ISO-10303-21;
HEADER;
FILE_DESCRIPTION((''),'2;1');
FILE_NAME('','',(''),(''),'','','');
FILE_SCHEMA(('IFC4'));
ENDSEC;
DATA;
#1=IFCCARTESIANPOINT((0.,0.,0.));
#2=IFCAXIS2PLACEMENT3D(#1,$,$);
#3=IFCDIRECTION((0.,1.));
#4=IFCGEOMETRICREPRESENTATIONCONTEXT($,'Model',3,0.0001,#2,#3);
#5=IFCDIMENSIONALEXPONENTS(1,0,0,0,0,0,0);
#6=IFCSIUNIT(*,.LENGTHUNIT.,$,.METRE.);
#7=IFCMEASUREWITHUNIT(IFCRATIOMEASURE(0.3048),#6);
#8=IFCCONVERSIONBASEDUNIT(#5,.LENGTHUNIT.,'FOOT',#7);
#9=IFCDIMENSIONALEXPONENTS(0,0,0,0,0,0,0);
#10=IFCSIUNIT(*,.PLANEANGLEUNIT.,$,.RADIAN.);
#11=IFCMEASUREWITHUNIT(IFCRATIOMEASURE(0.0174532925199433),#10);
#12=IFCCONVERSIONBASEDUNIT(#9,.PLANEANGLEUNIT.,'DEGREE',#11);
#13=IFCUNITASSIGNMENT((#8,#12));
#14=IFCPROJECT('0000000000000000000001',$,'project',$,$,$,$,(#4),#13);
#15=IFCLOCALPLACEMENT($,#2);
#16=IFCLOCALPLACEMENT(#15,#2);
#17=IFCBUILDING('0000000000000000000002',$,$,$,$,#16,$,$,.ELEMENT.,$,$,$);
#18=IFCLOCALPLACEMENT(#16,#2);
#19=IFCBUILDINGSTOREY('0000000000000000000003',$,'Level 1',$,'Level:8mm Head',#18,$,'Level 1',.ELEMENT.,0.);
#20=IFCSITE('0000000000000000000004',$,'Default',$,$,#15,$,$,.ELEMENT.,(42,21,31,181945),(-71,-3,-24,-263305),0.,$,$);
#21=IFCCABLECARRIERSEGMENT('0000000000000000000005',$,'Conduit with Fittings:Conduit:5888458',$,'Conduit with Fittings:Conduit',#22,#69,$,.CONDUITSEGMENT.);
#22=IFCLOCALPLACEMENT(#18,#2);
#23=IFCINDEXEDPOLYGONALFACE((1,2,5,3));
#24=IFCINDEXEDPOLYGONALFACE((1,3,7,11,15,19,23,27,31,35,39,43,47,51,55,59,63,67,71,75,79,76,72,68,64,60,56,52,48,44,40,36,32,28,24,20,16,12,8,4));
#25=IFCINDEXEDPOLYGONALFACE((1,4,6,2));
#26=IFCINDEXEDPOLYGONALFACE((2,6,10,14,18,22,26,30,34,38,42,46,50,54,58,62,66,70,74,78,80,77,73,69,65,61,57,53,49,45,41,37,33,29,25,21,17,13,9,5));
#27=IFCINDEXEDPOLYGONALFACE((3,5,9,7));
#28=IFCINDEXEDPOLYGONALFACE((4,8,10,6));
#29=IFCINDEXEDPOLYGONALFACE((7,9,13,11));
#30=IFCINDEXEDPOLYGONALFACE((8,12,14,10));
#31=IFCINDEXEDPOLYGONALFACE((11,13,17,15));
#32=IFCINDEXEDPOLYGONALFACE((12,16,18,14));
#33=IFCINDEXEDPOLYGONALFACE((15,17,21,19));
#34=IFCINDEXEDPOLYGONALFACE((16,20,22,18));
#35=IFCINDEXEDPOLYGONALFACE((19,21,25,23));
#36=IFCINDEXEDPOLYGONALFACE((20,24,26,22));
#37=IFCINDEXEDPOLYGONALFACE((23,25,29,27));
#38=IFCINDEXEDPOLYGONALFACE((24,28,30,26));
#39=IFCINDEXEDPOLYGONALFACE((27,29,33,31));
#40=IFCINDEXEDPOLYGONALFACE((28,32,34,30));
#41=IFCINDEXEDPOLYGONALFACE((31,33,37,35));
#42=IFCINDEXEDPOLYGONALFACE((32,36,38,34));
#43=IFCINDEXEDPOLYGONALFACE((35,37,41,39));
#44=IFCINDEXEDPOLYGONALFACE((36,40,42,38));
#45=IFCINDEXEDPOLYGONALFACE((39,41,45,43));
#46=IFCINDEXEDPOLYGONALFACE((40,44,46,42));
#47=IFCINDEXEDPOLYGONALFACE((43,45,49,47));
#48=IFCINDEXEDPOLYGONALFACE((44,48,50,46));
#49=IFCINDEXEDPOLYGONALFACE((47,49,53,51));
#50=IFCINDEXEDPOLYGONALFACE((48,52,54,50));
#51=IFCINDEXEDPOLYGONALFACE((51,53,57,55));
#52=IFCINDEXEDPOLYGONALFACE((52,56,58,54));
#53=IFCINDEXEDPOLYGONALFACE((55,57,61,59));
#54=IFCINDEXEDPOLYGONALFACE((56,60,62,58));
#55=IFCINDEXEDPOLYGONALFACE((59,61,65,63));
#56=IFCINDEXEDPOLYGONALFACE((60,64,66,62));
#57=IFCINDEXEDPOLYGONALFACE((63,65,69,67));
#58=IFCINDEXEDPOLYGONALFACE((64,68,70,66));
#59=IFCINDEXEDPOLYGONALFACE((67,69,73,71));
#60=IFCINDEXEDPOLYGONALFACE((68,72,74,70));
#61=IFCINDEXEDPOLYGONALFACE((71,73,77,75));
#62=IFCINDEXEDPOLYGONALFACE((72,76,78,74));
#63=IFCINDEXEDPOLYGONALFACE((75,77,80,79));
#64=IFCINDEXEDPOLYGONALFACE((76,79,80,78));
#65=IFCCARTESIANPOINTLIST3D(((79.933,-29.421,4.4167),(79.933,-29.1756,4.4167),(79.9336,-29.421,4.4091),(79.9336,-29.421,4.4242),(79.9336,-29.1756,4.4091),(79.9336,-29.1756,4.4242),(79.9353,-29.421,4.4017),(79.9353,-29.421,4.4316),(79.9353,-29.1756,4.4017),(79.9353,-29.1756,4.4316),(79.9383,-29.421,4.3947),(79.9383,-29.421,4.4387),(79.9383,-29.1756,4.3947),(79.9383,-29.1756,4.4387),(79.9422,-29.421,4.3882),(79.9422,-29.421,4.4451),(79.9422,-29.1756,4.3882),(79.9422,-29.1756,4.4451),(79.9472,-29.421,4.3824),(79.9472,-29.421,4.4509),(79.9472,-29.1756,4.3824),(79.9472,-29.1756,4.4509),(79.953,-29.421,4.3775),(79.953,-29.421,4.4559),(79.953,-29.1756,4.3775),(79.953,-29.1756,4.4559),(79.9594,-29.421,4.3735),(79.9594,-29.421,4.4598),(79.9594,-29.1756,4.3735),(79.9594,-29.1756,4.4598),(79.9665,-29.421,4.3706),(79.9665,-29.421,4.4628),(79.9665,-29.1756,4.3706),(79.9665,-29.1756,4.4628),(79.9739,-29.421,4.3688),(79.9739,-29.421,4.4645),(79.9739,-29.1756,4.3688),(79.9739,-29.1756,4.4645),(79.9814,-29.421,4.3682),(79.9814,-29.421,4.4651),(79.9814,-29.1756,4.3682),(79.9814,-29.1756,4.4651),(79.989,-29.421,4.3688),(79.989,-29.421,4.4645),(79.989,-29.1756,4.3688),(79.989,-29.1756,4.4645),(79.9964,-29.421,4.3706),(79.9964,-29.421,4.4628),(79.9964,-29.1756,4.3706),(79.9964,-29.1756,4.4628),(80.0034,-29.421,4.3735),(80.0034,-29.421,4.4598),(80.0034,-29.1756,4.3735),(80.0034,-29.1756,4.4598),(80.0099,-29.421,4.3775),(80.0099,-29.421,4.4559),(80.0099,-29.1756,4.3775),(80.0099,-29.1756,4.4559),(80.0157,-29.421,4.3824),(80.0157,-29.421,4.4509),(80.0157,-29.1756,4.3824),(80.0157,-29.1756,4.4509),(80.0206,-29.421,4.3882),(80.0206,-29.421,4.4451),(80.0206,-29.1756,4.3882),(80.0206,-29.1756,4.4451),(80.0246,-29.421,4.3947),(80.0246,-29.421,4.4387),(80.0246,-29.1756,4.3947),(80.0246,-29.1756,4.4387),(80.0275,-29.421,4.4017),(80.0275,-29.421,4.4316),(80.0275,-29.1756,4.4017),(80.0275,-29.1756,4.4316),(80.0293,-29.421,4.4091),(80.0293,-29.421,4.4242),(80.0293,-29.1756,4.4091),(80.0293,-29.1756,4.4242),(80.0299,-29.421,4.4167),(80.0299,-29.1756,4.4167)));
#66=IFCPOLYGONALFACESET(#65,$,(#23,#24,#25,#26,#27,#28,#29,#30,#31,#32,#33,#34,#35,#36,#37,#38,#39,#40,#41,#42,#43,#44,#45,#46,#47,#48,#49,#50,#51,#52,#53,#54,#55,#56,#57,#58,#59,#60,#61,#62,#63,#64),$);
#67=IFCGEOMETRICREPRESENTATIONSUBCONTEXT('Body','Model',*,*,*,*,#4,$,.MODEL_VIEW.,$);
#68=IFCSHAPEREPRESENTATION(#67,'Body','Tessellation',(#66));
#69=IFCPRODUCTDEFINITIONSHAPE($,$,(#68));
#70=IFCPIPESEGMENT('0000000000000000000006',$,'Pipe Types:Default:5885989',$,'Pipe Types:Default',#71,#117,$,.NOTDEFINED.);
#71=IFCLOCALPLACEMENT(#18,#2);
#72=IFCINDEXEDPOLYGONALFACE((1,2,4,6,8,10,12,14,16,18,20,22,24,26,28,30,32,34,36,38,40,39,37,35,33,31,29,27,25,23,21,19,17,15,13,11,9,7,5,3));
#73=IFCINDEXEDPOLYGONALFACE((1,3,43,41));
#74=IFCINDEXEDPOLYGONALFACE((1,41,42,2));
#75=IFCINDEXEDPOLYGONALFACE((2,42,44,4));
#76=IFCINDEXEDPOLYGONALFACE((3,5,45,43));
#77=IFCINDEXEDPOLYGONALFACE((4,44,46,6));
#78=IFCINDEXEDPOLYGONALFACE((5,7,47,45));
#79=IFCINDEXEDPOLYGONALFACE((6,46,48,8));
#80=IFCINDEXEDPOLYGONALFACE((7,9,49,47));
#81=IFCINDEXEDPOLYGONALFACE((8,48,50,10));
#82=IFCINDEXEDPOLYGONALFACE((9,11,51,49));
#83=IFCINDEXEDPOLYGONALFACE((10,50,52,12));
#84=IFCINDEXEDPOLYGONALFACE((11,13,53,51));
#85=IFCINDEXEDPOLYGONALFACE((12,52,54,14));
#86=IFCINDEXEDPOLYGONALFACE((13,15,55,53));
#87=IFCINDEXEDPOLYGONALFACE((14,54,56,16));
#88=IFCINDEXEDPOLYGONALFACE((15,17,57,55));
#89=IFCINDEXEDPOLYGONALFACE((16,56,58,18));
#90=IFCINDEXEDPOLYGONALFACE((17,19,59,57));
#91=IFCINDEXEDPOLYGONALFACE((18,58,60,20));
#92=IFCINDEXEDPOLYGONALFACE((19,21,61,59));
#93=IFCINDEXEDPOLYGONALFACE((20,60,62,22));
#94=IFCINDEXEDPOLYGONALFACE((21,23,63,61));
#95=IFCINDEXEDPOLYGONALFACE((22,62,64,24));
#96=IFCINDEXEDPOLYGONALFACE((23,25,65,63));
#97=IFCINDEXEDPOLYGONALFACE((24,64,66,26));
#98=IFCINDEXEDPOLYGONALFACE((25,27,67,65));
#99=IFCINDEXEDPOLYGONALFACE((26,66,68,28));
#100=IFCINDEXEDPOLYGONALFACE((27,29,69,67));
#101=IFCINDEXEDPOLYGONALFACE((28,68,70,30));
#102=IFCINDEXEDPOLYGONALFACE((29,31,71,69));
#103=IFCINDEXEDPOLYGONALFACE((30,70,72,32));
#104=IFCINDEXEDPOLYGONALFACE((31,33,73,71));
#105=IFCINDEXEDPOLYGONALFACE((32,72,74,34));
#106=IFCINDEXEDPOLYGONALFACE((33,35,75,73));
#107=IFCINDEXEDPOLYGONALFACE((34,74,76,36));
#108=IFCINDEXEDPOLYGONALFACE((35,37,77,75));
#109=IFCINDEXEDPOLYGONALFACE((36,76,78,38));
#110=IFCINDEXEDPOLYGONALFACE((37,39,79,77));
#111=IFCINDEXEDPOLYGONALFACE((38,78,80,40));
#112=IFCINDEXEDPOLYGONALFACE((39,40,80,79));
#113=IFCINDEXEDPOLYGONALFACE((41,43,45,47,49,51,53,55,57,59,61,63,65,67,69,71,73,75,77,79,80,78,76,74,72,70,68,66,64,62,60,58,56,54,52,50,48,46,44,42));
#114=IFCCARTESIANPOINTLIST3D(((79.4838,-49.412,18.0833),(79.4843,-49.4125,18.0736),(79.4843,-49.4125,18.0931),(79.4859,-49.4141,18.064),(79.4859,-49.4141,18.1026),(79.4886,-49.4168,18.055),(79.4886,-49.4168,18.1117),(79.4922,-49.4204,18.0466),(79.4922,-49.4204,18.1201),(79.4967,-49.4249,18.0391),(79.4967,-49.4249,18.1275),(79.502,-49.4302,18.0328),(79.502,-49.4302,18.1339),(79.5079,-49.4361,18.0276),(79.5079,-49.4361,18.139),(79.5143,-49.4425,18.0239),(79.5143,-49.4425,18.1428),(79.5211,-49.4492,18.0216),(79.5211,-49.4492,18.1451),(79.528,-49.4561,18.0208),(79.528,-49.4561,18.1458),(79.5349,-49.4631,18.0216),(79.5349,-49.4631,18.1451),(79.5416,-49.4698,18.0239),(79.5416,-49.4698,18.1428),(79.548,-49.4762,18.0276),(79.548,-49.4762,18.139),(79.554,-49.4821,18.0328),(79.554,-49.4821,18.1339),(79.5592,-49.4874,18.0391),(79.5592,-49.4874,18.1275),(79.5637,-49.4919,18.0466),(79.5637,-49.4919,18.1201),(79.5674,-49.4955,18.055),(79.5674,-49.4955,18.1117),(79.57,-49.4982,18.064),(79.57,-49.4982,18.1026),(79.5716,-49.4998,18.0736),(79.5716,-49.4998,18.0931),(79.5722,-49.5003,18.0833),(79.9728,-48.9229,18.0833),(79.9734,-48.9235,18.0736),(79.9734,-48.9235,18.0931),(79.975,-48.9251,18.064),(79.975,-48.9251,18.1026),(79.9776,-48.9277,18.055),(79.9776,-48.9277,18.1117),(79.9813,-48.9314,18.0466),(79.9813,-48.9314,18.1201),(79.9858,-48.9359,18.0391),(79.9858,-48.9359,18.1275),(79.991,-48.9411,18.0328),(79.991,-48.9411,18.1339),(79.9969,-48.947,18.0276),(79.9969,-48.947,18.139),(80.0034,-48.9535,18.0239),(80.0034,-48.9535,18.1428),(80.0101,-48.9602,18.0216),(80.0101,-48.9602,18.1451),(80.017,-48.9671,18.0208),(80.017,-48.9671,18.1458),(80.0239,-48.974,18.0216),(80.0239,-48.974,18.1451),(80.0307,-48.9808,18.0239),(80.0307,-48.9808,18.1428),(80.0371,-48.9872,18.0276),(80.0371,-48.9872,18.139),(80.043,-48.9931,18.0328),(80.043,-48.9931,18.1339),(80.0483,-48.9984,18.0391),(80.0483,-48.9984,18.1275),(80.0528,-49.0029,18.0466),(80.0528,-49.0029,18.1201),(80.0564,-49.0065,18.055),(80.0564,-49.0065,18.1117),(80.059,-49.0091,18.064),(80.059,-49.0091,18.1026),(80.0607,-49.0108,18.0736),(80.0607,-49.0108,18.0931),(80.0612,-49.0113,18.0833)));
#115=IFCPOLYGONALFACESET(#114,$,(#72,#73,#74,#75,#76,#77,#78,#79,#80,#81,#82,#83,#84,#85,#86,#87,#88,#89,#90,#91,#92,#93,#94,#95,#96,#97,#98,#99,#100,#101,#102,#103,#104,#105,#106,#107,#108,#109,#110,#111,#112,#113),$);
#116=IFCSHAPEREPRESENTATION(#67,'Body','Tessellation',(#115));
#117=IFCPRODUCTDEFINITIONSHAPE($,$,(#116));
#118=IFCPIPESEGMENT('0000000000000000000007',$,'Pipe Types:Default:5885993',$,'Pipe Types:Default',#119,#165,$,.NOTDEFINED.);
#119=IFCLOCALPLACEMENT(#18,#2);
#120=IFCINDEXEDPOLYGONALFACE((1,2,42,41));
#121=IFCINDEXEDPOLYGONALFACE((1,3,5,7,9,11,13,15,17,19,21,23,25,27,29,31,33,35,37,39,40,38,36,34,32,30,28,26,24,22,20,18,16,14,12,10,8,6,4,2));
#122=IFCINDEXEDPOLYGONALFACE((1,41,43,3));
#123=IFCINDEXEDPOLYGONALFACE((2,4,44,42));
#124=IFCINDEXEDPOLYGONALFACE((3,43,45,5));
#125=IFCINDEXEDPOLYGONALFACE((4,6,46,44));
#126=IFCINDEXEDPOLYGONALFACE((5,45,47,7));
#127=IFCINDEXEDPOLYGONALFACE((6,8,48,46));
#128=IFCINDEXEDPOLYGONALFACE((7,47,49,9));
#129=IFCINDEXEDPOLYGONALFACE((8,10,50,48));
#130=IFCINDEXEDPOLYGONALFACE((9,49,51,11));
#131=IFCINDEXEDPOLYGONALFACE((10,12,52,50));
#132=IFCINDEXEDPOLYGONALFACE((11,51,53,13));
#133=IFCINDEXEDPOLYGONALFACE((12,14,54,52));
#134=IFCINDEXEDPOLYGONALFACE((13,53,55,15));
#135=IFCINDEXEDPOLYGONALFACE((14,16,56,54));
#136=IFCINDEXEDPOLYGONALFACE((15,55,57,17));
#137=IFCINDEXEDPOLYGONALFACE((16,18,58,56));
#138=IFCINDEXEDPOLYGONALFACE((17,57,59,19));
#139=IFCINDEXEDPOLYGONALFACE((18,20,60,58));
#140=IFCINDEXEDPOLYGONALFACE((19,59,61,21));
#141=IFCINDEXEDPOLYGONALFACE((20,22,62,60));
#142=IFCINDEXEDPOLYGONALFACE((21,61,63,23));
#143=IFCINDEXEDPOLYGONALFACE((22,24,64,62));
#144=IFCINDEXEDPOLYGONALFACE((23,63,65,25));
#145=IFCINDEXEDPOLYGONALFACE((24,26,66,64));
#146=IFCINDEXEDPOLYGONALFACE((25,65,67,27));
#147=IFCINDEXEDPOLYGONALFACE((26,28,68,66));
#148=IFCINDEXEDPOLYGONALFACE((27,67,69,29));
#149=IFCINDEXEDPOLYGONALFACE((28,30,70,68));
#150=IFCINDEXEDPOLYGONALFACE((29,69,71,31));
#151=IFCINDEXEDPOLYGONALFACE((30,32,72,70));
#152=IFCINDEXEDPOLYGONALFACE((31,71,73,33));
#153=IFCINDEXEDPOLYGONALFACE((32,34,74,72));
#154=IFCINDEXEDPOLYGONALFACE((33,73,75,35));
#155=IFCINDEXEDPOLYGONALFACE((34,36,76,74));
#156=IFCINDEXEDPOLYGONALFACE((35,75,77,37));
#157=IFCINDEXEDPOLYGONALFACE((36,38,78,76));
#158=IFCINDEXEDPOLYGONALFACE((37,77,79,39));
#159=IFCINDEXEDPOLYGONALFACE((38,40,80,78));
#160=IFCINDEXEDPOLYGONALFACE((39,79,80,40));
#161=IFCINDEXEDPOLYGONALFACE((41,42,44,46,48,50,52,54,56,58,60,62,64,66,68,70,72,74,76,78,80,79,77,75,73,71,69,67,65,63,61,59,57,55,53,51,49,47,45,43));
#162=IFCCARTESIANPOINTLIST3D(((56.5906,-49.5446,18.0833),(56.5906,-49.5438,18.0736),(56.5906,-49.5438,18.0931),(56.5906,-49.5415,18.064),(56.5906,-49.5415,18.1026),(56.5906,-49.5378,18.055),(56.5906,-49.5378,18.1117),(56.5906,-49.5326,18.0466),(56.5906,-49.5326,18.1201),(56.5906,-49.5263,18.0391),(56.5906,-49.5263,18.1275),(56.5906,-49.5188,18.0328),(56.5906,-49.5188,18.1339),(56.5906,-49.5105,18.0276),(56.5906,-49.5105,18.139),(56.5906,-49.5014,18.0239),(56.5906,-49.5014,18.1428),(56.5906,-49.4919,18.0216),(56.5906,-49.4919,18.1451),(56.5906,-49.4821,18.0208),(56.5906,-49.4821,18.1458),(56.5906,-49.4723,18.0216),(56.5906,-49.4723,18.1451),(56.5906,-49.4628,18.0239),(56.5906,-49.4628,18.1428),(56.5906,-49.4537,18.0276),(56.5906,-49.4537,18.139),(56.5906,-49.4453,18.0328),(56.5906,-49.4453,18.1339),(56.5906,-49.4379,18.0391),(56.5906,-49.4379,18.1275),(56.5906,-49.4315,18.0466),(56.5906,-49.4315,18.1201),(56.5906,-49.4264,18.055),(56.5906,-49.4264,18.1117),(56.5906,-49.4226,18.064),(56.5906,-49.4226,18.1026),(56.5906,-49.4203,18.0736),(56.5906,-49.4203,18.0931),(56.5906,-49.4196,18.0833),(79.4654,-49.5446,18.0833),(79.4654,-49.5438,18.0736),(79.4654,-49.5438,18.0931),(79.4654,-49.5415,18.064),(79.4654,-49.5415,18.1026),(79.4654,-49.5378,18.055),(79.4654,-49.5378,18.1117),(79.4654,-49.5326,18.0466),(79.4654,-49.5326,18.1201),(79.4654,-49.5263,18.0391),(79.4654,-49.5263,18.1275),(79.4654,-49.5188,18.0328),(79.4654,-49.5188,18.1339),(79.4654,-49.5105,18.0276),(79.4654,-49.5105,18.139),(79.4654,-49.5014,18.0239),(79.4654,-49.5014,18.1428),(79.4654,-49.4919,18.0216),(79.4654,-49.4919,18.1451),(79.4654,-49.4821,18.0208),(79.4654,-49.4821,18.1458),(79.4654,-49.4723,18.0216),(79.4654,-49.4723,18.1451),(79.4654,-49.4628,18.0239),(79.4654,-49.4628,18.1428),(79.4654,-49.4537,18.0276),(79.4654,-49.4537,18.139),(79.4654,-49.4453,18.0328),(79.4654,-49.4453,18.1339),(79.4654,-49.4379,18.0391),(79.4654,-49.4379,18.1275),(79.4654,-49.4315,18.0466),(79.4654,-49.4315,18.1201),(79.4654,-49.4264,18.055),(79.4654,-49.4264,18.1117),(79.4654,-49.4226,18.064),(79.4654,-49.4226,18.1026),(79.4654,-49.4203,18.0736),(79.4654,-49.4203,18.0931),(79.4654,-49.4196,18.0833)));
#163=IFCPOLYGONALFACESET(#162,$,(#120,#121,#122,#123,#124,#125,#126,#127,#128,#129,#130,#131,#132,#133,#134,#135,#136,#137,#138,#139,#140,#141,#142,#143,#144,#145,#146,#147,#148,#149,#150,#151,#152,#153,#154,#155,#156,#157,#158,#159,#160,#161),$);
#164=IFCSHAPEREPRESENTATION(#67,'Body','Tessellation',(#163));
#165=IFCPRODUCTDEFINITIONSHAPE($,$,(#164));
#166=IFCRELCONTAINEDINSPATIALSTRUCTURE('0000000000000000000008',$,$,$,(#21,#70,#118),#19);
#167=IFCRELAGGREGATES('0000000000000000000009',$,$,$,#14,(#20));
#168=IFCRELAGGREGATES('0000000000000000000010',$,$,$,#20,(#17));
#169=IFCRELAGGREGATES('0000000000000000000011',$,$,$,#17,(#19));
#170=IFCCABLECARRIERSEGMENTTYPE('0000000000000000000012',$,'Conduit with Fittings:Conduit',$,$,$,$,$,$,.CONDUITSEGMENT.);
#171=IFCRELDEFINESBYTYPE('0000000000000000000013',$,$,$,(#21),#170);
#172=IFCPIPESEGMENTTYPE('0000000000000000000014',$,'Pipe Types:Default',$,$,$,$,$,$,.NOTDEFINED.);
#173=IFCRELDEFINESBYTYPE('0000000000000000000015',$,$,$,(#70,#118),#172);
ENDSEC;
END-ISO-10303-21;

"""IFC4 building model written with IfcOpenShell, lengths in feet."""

from ifc_helpers import new_model, entity, si_unit, converted_unit, direction, frame, origin, place, context, subcontext, project, spatial, indexed_curve, outline, extrude, type_object, element, save


model = new_model("IFC4")

# Units and contexts
model_context = context("Model", 3, precision=0.0001, world=origin(), true_north=direction((0.0, 1.0)))
body_context = subcontext(model_context, "Body", "Model", "MODEL_VIEW")
ifc_project = project(units=[converted_unit("LENGTHUNIT", "FOOT", entity("IfcRatioMeasure", 0.3048), si_unit("LENGTHUNIT", "METRE"), dimensions=[1, 0, 0, 0, 0, 0, 0]), converted_unit("PLANEANGLEUNIT", "DEGREE", entity("IfcRatioMeasure", 0.0174532925199433), si_unit("PLANEANGLEUNIT", "RADIAN"), dimensions=[0, 0, 0, 0, 0, 0, 0])], contexts=[model_context])

# Site, building, storey
site_placement = place(None, origin())
site = spatial("IfcSite", under=ifc_project, at=site_placement, Name="Default", CompositionType="ELEMENT", RefLatitude=(42, 21, 31, 181945), RefLongitude=(-71, -3, -24, -263305), RefElevation=0.0)
building_placement = place(site_placement, origin())
building = spatial("IfcBuilding", under=site, at=building_placement, CompositionType="ELEMENT")
storey_placement = place(building_placement, origin())
storey = spatial("IfcBuildingStorey", under=building, at=storey_placement, Name="Level 1", ObjectType="Level:8mm Head", LongName="Level 1", CompositionType="ELEMENT", Elevation=0.0)

# Cable carrier segment
cable_carrier_segment_type = type_object("IfcCableCarrierSegmentType", Name="Conduit with Fittings:Conduit", PredefinedType="CONDUITSEGMENT")
cable_carrier_segment_1_placement = place(storey_placement, origin())
element("IfcCableCarrierSegment", 1, at=cable_carrier_segment_1_placement, inside=storey, type_object=cable_carrier_segment_type, Name="Conduit with Fittings:Conduit:5888458", ObjectType="Conduit with Fittings:Conduit", PredefinedType="CONDUITSEGMENT", context=body_context, shape_type="SweptSolid", body=[
    extrude(outline(indexed_curve([(0.0485, 0.0), (0.0479, 0.0076), (0.0461, 0.015), (0.0432, 0.022), (0.0392, 0.0285), (0.0343, 0.0343), (0.0285, 0.0392), (0.022, 0.0432), (0.015, 0.0461), (0.0076, 0.0479), (0.0, 0.0485), (-0.0076, 0.0479), (-0.015, 0.0461), (-0.022, 0.0432), (-0.0285, 0.0392), (-0.0343, 0.0343), (-0.0392, 0.0285), (-0.0432, 0.022), (-0.0461, 0.015), (-0.0479, 0.0076), (-0.0485, 0.0), (-0.0479, -0.0076), (-0.0461, -0.015), (-0.0432, -0.022), (-0.0392, -0.0285), (-0.0343, -0.0343), (-0.0285, -0.0392), (-0.022, -0.0432), (-0.015, -0.0461), (-0.0076, -0.0479), (0.0, -0.0485), (0.0076, -0.0479), (0.015, -0.0461), (0.022, -0.0432), (0.0285, -0.0392), (0.0343, -0.0343), (0.0392, -0.0285), (0.0432, -0.022), (0.0461, -0.015), (0.0479, -0.0076), (0.0485, 0.0)], self_intersect=False)), frame((79.9814, -29.421, 4.4167), z_axis=(0.0, 1.0, 0.0), x_axis=(-1.0, 0.0, 0.0)), (0.0, 0.0, 1.0), 0.2454),
])

# Pipe segments
pipe_segment_type = type_object("IfcPipeSegmentType", Name="Pipe Types:Default", PredefinedType="NOTDEFINED")
pipe_segment_1_placement = place(storey_placement, origin())
element("IfcPipeSegment", 2, at=pipe_segment_1_placement, inside=storey, type_object=pipe_segment_type, Name="Pipe Types:Default:5885989", ObjectType="Pipe Types:Default", PredefinedType="NOTDEFINED", context=body_context, shape_type="SweptSolid", body=[
    extrude(outline(indexed_curve([(0.0625, 0.0), (0.0617, 0.0098), (0.0594, 0.0193), (0.0557, 0.0284), (0.0506, 0.0367), (0.0442, 0.0442), (0.0367, 0.0506), (0.0284, 0.0557), (0.0193, 0.0594), (0.0098, 0.0617), (0.0, 0.0625), (-0.0098, 0.0617), (-0.0193, 0.0594), (-0.0284, 0.0557), (-0.0367, 0.0506), (-0.0442, 0.0442), (-0.0506, 0.0367), (-0.0557, 0.0284), (-0.0594, 0.0193), (-0.0617, 0.0098), (-0.0625, 0.0), (-0.0617, -0.0098), (-0.0594, -0.0193), (-0.0557, -0.0284), (-0.0506, -0.0367), (-0.0442, -0.0442), (-0.0367, -0.0506), (-0.0284, -0.0557), (-0.0193, -0.0594), (-0.0098, -0.0617), (0.0, -0.0625), (0.0098, -0.0617), (0.0193, -0.0594), (0.0284, -0.0557), (0.0367, -0.0506), (0.0442, -0.0442), (0.0506, -0.0367), (0.0557, -0.0284), (0.0594, -0.0193), (0.0617, -0.0098), (0.0625, 0.0)], self_intersect=False)), frame((79.528, -49.4561, 18.0833), z_axis=(0.707107, 0.707107, 0.0), x_axis=(-0.707107, 0.707107, 0.0)), (0.0, 0.0, 1.0), 0.6916),
])
pipe_segment_2_placement = place(storey_placement, origin())
element("IfcPipeSegment", 3, at=pipe_segment_2_placement, inside=storey, type_object=pipe_segment_type, Name="Pipe Types:Default:5885993", ObjectType="Pipe Types:Default", PredefinedType="NOTDEFINED", context=body_context, shape_type="SweptSolid", body=[
    extrude(outline(indexed_curve([(0.0625, 0.0), (0.0617, 0.0098), (0.0594, 0.0193), (0.0557, 0.0284), (0.0506, 0.0367), (0.0442, 0.0442), (0.0367, 0.0506), (0.0284, 0.0557), (0.0193, 0.0594), (0.0098, 0.0617), (0.0, 0.0625), (-0.0098, 0.0617), (-0.0193, 0.0594), (-0.0284, 0.0557), (-0.0367, 0.0506), (-0.0442, 0.0442), (-0.0506, 0.0367), (-0.0557, 0.0284), (-0.0594, 0.0193), (-0.0617, 0.0098), (-0.0625, 0.0), (-0.0617, -0.0098), (-0.0594, -0.0193), (-0.0557, -0.0284), (-0.0506, -0.0367), (-0.0442, -0.0442), (-0.0367, -0.0506), (-0.0284, -0.0557), (-0.0193, -0.0594), (-0.0098, -0.0617), (0.0, -0.0625), (0.0098, -0.0617), (0.0193, -0.0594), (0.0284, -0.0557), (0.0367, -0.0506), (0.0442, -0.0442), (0.0506, -0.0367), (0.0557, -0.0284), (0.0594, -0.0193), (0.0617, -0.0098), (0.0625, 0.0)], self_intersect=False)), frame((56.5906, -49.4821, 18.0833), z_axis=(1.0, 0.0, 0.0), x_axis=(0.0, 1.0, 0.0)), (0.0, 0.0, 1.0), 22.8748),
])

save(model, "model.ifc")
